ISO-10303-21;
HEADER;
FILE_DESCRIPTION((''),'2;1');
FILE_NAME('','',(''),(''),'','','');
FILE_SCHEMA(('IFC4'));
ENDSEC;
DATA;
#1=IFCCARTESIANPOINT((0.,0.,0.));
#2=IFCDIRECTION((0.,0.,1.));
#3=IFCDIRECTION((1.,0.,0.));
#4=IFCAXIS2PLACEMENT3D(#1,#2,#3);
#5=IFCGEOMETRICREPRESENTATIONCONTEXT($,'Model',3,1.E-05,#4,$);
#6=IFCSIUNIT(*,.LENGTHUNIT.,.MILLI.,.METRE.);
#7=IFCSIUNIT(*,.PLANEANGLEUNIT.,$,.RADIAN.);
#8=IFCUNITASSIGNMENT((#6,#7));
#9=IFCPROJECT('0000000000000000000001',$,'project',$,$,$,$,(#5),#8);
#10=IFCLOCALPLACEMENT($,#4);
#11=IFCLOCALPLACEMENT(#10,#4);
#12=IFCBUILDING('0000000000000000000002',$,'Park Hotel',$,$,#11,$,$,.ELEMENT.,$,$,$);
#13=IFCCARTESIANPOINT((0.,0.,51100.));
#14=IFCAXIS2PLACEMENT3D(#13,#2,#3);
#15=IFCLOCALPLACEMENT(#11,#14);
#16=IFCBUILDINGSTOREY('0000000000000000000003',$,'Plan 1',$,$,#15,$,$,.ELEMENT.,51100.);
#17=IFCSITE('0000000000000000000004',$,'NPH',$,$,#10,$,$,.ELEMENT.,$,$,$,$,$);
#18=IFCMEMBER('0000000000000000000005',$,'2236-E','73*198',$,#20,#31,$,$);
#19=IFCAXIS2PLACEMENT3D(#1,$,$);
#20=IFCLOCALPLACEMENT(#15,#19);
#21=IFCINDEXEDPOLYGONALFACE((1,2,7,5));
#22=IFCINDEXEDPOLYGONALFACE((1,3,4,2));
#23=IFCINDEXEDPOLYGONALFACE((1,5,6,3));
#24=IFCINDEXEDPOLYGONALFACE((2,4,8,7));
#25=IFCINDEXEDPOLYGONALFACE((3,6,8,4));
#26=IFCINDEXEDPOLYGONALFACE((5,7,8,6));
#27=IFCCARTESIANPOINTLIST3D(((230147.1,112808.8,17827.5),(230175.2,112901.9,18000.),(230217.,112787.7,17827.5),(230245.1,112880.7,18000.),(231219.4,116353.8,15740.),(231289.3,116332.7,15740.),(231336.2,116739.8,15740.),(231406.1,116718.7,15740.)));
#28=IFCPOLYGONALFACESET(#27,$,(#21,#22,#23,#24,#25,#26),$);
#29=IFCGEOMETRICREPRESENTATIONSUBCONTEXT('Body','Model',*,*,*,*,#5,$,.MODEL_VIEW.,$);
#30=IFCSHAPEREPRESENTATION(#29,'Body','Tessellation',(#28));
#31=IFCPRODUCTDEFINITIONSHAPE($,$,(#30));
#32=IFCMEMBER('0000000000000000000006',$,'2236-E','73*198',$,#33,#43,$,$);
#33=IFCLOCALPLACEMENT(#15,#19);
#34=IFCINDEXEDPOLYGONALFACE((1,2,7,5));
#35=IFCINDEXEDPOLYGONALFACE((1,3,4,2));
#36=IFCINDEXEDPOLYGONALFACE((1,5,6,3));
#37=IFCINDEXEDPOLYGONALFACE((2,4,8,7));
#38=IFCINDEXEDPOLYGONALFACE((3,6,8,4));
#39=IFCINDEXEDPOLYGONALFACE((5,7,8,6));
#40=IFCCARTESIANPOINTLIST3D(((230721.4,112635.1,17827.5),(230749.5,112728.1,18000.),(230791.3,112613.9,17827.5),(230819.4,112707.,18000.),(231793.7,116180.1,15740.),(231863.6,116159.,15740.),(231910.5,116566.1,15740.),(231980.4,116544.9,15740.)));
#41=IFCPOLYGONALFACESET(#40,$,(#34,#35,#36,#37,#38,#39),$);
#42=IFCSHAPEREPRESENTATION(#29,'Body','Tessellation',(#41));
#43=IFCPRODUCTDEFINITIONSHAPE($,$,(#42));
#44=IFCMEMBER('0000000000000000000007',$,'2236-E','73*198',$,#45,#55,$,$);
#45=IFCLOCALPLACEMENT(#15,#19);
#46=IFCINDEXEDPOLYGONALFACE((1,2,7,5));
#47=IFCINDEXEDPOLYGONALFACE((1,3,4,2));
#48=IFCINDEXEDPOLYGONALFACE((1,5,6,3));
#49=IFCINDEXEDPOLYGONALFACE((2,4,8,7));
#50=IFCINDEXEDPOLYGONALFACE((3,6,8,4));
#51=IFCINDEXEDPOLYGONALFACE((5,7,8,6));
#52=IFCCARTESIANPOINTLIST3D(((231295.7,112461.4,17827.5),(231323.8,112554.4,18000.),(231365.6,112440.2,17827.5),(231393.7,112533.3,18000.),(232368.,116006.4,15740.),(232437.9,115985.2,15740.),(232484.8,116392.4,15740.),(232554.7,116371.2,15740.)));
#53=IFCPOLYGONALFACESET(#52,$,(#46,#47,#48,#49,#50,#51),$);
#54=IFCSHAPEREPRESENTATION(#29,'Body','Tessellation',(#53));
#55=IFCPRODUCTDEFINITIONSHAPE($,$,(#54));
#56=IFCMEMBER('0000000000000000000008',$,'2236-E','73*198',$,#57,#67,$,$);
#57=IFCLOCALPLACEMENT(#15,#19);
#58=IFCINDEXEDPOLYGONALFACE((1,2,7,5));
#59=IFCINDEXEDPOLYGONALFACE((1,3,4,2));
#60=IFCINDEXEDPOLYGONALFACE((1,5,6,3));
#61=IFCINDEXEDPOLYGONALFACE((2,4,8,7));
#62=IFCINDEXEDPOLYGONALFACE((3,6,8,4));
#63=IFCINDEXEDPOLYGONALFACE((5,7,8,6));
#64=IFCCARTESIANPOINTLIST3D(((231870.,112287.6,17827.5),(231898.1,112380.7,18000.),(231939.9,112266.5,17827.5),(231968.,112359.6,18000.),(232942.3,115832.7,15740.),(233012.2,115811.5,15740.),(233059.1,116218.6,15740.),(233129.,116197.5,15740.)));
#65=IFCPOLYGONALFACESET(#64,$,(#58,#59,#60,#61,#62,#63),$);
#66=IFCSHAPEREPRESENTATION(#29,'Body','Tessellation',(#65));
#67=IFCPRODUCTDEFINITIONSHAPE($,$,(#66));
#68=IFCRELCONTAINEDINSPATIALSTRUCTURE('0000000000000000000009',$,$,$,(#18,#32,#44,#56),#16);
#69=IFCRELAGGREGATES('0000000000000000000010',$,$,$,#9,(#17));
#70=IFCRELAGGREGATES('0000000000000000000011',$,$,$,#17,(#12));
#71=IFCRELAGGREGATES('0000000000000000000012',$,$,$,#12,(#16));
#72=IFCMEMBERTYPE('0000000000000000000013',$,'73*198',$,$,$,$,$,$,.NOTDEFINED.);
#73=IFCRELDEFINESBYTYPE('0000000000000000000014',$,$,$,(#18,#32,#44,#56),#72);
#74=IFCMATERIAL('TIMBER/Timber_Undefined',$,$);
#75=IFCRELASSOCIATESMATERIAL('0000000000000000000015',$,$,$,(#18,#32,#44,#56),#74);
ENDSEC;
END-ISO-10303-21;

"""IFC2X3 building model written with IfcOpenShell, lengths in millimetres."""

from ifc_helpers import new_model, si_unit, frame, origin_with_axes, origin_2d_with_axis, place, context, subcontext, project, spatial, rectangle, extrude, clip, halfspace, material, type_object, element, save


model = new_model("IFC2X3")

# Units and contexts
model_context = context("Model", 3, precision=1e-05, world=origin_with_axes())
body_context = subcontext(model_context, "Body", "Model", "MODEL_VIEW")
ifc_project = project(units=[si_unit("LENGTHUNIT", "METRE", prefix="MILLI"), si_unit("PLANEANGLEUNIT", "RADIAN")], contexts=[model_context])

# Site, building, storey
site_placement = place(None, origin_with_axes())
site = spatial("IfcSite", under=ifc_project, at=site_placement, Name="NPH", CompositionType="ELEMENT")
building_placement = place(site_placement, origin_with_axes())
building = spatial("IfcBuilding", under=site, at=building_placement, Name="Park Hotel", CompositionType="ELEMENT")
storey_placement = place(building_placement, frame((0.0, 0.0, 51100.0), z_axis=(0.0, 0.0, 1.0), x_axis=(1.0, 0.0, 0.0)))
storey = spatial("IfcBuildingStorey", under=building, at=storey_placement, Name="Plan 1", CompositionType="ELEMENT", Elevation=51100.0)

# Shared definitions
ifc_material = material(Name="TIMBER/Timber_Undefined")

# Members
member_type = type_object("IfcMemberType", Name="73*198", PredefinedType="NOTDEFINED")
for number, where, z_axis, x_axis, name in (
    (1, (230196.1, 112844.8, 17913.8), (-0.957167, 0.289538, 0.0), (0.252232, 0.833838, -0.491013), "2236-E"),
    (2, (230770.4, 112671.0, 17913.8), (-0.957167, 0.289538, 0.0), (0.252232, 0.833838, -0.491013), "2236-E"),
    (3, (231344.7, 112497.3, 17913.8), (-0.957167, 0.289538, 0.0), (0.252232, 0.833838, -0.491013), "2236-E"),
    (4, (231919.0, 112323.6, 17913.8), (-0.957167, 0.289538, 0.0), (0.252232, 0.833838, -0.491013), "2236-E"),
):
    element("IfcMember", number, at=place(storey_placement, frame(where, z_axis=z_axis, x_axis=x_axis)), inside=storey, type_object=member_type, material=ifc_material, Name=name, Description="73*198", context=body_context, shape_type="Clipping", body=[
        clip(extrude(rectangle(XDim=198.0, YDim=73.0, at=origin_2d_with_axis()), frame((9470.2, 0.0, 0.0), z_axis=(-1.0, 0.0, 0.0), x_axis=(0.0, -1.0, 0.0)), (0.0, 0.0, 1.0), 9470.2), halfspace(frame((4746.2, -179.9, -36.5), z_axis=(0.491013, 0.871152, 0.0), x_axis=(0.0, 0.0, 1.0)), False)),
    ])

save(model, "model.ifc")
